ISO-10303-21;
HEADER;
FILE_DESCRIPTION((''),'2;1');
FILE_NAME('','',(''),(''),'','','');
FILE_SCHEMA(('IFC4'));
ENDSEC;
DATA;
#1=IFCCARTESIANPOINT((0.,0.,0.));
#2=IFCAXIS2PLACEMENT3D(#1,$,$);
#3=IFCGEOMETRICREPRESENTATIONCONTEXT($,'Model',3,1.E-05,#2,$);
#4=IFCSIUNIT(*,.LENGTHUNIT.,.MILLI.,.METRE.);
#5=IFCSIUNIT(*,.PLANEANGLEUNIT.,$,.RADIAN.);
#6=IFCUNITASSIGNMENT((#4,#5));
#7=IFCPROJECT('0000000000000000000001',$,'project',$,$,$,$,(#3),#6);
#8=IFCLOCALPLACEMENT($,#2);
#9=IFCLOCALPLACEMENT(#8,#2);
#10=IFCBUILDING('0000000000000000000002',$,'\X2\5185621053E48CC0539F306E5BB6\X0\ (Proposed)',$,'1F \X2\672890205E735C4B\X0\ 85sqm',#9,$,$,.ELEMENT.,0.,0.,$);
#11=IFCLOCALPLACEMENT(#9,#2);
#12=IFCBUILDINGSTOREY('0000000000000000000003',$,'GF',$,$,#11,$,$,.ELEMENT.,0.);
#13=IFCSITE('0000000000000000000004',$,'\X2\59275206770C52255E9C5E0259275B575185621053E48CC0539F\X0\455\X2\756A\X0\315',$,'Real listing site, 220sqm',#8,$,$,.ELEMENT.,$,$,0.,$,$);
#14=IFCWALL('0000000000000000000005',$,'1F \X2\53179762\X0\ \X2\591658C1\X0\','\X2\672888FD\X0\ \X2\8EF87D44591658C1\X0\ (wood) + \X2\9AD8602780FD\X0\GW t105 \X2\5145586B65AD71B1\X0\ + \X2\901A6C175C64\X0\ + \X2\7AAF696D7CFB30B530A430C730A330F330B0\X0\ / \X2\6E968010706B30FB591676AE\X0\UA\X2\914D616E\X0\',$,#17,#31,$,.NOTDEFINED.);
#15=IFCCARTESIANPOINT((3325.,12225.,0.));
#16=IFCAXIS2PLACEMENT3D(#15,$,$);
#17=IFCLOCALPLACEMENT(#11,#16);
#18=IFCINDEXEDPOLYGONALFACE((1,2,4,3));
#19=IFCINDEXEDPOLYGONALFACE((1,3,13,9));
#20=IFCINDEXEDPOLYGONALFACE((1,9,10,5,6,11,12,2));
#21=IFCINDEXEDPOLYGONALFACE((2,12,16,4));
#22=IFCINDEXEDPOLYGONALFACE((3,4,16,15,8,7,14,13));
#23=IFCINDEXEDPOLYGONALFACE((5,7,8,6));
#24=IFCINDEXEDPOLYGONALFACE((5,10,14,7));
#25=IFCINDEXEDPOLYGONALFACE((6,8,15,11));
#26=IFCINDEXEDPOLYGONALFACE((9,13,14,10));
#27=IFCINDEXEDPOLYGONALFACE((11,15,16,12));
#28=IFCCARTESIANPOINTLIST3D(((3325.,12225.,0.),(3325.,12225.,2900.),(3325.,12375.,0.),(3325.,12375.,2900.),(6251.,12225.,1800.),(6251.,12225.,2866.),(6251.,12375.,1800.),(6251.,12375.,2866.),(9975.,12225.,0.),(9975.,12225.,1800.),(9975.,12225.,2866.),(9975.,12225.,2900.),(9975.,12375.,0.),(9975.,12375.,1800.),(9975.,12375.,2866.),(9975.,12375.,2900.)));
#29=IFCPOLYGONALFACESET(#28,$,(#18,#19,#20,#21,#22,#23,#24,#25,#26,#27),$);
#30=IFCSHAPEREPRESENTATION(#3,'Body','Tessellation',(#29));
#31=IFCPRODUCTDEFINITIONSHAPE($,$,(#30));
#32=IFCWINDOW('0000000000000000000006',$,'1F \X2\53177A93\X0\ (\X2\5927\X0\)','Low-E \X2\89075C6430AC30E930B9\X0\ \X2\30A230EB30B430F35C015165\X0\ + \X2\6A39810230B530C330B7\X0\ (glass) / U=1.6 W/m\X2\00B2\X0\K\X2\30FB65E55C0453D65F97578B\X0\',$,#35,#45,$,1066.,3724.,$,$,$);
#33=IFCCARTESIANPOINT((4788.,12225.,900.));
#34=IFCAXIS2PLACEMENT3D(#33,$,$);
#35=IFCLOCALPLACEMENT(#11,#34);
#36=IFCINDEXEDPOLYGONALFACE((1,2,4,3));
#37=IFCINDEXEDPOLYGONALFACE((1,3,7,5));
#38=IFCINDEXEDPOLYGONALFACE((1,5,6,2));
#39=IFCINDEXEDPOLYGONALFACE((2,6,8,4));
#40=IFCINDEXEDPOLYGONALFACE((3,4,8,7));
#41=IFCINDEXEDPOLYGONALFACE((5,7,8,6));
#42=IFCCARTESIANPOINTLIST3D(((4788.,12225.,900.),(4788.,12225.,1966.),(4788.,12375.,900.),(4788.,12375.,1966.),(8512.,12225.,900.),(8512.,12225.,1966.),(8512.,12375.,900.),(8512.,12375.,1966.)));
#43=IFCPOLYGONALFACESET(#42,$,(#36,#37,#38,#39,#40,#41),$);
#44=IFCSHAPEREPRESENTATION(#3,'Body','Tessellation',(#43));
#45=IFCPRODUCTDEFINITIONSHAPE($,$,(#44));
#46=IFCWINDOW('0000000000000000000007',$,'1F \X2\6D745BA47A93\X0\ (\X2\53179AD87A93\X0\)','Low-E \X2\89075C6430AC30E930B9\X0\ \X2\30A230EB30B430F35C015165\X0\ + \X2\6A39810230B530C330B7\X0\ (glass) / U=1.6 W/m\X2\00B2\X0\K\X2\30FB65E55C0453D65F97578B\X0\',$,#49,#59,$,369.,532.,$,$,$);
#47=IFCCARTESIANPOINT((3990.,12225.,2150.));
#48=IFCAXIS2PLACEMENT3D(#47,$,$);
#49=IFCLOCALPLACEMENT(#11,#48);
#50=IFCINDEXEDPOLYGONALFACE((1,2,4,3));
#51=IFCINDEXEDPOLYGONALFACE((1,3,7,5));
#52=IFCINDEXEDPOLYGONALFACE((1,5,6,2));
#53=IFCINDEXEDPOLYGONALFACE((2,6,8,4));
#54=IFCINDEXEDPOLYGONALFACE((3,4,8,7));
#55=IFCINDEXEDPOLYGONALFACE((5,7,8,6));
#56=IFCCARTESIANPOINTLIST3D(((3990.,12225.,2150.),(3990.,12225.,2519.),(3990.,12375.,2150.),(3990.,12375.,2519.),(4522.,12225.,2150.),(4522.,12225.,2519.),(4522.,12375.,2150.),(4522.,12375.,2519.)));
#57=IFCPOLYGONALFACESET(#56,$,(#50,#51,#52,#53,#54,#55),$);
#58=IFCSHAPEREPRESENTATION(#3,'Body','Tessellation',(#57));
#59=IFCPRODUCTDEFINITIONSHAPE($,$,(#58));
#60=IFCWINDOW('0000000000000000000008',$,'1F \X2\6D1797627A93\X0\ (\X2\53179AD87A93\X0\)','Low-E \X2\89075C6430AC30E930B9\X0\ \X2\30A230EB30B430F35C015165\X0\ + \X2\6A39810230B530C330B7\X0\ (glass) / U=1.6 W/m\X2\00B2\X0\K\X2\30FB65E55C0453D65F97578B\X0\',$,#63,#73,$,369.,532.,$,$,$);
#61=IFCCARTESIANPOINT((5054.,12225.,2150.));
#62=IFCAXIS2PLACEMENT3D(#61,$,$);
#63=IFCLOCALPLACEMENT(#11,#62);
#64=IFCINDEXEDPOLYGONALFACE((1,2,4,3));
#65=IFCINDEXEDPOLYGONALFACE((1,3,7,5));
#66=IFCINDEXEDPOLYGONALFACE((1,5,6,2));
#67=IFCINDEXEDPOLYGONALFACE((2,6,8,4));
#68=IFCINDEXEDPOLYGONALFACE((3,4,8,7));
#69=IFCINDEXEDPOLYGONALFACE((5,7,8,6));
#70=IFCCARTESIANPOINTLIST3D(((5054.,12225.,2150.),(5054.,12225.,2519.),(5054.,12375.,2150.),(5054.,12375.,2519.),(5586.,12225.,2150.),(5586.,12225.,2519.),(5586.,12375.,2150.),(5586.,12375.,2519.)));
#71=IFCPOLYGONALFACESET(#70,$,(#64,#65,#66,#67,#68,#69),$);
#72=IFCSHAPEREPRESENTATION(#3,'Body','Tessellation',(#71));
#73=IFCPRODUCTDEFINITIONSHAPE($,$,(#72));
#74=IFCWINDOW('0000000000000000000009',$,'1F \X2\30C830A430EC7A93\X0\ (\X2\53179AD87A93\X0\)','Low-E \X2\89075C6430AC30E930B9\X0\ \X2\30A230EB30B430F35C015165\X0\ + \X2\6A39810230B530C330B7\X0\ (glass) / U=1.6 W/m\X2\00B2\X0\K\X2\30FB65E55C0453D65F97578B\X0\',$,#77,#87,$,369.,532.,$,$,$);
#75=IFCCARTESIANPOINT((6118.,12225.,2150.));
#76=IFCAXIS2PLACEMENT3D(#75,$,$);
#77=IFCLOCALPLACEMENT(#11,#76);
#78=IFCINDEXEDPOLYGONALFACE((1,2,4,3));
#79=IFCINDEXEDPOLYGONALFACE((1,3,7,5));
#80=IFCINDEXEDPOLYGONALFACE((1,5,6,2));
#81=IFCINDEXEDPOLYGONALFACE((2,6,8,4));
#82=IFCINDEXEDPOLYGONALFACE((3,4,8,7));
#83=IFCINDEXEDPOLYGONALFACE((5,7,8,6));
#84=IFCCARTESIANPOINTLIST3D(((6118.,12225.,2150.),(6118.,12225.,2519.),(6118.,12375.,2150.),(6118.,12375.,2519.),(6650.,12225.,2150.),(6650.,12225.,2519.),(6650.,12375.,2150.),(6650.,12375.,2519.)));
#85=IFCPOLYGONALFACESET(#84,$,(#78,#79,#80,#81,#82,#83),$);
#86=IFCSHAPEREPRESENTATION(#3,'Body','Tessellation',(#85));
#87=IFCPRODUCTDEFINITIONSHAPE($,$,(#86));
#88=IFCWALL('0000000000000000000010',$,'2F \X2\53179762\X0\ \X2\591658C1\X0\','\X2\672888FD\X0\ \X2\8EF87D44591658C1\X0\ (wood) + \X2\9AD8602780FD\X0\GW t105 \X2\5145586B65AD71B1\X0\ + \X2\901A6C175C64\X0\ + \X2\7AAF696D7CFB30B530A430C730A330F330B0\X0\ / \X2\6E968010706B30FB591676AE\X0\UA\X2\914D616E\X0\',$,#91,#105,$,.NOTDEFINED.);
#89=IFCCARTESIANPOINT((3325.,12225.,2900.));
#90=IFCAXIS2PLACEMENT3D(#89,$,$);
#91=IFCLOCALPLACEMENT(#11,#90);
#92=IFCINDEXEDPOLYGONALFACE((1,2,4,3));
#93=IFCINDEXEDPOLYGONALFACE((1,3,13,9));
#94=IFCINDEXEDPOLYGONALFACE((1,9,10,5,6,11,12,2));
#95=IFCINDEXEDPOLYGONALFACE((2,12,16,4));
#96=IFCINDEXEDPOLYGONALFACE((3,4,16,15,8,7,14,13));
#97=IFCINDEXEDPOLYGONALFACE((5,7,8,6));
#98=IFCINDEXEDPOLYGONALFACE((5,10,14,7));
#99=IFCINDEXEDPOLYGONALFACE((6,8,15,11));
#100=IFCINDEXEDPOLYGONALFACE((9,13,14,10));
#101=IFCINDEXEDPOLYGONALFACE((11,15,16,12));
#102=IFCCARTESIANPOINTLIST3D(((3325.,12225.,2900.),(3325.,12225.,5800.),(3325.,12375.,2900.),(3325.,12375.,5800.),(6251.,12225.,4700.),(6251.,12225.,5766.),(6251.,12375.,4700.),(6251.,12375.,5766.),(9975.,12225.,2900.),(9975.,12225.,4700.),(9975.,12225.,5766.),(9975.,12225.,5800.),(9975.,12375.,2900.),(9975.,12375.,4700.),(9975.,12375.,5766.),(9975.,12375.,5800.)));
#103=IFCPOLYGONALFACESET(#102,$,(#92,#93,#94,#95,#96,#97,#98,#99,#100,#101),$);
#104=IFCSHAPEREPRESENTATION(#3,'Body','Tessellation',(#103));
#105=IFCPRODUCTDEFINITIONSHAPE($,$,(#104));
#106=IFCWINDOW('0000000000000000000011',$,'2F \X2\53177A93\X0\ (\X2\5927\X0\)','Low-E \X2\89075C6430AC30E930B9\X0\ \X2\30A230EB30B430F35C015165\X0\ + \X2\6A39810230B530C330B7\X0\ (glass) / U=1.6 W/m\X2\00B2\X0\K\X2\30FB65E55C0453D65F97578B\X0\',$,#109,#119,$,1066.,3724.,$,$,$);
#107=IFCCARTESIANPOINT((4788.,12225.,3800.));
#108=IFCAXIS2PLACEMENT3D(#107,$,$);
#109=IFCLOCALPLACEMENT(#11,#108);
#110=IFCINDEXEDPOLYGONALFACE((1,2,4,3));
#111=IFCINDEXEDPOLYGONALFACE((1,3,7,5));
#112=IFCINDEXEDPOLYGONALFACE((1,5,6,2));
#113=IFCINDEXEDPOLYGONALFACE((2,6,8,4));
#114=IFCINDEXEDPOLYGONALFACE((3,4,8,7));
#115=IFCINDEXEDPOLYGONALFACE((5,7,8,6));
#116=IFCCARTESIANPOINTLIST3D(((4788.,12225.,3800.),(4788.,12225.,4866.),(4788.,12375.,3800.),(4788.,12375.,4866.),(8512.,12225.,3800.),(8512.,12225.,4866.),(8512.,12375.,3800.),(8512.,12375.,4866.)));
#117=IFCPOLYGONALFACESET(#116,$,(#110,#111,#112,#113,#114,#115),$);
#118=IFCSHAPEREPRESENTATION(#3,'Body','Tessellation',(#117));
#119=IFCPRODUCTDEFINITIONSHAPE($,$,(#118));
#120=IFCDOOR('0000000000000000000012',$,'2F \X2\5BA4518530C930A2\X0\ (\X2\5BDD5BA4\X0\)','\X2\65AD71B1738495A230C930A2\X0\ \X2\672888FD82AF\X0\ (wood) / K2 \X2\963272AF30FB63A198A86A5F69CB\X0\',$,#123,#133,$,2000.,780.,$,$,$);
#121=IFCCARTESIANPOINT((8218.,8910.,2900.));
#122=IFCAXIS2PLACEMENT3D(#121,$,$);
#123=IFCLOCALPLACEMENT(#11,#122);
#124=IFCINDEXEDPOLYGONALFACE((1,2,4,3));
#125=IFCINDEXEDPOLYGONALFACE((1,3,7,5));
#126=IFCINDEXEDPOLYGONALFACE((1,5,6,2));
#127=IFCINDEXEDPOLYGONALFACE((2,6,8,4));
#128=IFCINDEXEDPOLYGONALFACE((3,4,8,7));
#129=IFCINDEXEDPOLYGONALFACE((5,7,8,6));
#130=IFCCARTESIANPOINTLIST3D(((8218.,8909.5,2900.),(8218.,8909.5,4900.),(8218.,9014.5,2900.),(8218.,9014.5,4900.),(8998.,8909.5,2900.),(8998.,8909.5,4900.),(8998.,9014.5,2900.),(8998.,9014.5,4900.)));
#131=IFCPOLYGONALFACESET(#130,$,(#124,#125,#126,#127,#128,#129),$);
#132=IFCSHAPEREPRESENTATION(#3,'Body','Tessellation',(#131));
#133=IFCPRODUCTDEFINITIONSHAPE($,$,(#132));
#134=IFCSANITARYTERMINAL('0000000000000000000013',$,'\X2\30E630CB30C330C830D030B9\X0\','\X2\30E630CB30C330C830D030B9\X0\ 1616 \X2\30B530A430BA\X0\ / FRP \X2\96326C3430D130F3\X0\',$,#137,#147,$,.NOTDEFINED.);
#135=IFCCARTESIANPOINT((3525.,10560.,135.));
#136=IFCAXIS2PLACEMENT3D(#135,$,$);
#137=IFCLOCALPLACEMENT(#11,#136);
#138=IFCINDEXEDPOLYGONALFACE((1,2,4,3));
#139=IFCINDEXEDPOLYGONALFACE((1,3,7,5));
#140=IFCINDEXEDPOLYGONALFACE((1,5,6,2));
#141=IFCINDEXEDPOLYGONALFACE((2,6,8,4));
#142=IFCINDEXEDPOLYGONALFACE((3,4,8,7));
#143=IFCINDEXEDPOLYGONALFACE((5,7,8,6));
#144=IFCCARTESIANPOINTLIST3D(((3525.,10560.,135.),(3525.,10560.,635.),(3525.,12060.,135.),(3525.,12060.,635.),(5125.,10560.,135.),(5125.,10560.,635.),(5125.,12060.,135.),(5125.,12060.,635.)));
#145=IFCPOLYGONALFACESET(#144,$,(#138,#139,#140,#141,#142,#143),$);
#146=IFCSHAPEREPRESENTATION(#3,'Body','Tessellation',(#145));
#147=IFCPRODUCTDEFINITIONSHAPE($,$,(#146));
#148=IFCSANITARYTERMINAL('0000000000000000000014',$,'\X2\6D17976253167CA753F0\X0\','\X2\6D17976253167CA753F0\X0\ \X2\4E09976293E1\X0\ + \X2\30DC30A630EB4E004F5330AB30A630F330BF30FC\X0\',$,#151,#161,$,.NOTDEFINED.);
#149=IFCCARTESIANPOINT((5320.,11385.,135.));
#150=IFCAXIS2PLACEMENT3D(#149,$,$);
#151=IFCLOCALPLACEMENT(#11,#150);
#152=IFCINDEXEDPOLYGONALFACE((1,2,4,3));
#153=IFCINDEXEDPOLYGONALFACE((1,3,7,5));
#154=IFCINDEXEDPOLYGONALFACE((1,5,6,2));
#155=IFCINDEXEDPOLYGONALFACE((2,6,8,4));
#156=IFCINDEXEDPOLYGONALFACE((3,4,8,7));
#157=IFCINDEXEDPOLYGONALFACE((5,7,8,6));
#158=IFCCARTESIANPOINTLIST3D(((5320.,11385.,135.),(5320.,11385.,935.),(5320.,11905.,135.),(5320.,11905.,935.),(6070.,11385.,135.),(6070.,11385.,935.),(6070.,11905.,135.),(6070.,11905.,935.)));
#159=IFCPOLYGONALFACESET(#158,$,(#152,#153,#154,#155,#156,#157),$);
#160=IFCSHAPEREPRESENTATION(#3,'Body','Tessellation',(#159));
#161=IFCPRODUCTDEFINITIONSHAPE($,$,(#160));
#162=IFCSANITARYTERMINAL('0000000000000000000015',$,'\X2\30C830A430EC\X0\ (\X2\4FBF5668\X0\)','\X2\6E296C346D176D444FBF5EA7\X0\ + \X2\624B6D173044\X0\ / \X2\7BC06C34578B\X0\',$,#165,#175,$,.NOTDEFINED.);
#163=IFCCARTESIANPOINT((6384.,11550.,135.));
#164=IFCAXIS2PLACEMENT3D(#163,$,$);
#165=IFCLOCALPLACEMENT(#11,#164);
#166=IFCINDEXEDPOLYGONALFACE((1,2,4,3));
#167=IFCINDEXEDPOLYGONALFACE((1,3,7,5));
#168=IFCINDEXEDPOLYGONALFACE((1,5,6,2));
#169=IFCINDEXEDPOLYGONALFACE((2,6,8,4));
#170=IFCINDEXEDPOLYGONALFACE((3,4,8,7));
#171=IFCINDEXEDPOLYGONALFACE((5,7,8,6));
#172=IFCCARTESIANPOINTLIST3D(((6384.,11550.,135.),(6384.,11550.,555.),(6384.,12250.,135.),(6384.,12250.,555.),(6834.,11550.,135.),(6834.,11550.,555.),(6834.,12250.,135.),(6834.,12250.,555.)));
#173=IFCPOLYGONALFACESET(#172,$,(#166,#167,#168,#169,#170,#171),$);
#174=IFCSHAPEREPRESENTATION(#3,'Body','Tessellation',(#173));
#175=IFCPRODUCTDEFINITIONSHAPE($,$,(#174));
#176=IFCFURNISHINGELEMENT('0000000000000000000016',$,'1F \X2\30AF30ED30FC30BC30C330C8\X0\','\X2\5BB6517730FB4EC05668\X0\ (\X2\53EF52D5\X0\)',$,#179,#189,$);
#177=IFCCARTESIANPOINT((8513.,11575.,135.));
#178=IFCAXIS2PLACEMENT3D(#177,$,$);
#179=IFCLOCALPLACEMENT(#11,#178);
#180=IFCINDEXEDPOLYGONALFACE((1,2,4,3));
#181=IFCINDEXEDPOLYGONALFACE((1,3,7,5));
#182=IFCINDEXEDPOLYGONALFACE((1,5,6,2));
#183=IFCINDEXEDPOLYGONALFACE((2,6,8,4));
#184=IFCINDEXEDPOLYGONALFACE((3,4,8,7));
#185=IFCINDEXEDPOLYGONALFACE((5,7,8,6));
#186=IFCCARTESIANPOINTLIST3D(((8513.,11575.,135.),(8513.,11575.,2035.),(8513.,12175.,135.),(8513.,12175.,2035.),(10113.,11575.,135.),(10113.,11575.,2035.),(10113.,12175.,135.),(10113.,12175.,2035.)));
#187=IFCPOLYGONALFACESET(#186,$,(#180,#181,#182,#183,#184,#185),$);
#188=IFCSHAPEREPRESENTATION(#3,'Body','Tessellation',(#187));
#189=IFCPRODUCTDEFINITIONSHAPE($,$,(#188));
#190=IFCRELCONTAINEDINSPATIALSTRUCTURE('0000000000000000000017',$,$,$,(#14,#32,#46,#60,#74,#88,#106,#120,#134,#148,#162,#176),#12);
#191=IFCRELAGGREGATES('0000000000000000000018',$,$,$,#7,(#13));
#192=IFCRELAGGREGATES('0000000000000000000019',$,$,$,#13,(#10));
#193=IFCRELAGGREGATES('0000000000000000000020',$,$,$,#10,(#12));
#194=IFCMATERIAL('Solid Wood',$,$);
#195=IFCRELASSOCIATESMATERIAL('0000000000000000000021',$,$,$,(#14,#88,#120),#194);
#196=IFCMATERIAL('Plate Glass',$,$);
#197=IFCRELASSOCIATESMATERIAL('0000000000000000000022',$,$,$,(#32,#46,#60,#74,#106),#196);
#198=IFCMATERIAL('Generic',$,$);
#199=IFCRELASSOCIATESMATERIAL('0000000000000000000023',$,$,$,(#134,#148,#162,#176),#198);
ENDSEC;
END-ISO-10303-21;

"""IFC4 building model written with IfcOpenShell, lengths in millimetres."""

from ifc_helpers import new_model, si_unit, frame, frame_2d, origin, place, context, project, spatial, rectangle, extrude, material, element, fill, save


model = new_model("IFC4")

# Units and contexts
model_context = context("Model", 3, precision=1e-05, world=origin())
ifc_project = project(units=[si_unit("LENGTHUNIT", "METRE", prefix="MILLI"), si_unit("PLANEANGLEUNIT", "RADIAN")], contexts=[model_context])

# Site, building, storey
site_placement = place(None, origin())
site = spatial("IfcSite", under=ifc_project, at=site_placement, Name="大分県別府市大字内成古賀原455番315", ObjectType="Real listing site, 220sqm", CompositionType="ELEMENT", RefElevation=0.0)
building_placement = place(site_placement, origin())
building = spatial("IfcBuilding", under=site, at=building_placement, Name="内成古賀原の家 (Proposed)", ObjectType="1F 木造平屋 85sqm", CompositionType="ELEMENT", ElevationOfRefHeight=0.0, ElevationOfTerrain=0.0)
storey_placement = place(building_placement, origin())
storey = spatial("IfcBuildingStorey", under=building, at=storey_placement, Name="GF", CompositionType="ELEMENT", Elevation=0.0)

# Wall, openings, windows
ifc_material_1 = material(Name="Solid Wood")
wall_1_placement = place(storey_placement, frame((3325.0, 12225.0, 0.0)))
wall_1 = element("IfcWall", 1, at=wall_1_placement, inside=storey, material=ifc_material_1, Name="1F 北面 外壁", Description="木製 軸組外壁 (wood) + 高性能GW t105 充填断熱 + 通気層 + 窯業系サイディング / 準耐火・外皮UA配慮", PredefinedType="NOTDEFINED", context=model_context, shape_type="SweptSolid", body=[
    extrude(rectangle(XDim=6650.0, YDim=150.0, at=frame_2d((3325.0, 75.0))), frame((3325.0, 12225.0, 0.0)), (0.0, 0.0, 1.0), 2900.0),
])
opening_1_placement = place(storey_placement, frame((4788.0, 12225.0, 900.0)))
opening_1 = element("IfcOpeningElement", 2, at=opening_1_placement, cuts=wall_1, PredefinedType="NOTDEFINED", context=model_context, shape_type="SweptSolid", body=[
    extrude(rectangle(XDim=3724.0, YDim=150.0, at=frame_2d((1862.0, 75.0))), frame((4788.0, 12225.0, 900.0)), (0.0, 0.0, 1.0), 1066.0),
])
opening_2_placement = place(storey_placement, frame((3990.0, 12225.0, 2150.0)))
opening_2 = element("IfcOpeningElement", 3, at=opening_2_placement, cuts=wall_1, PredefinedType="NOTDEFINED", context=model_context, shape_type="SweptSolid", body=[
    extrude(rectangle(XDim=532.0, YDim=150.0, at=frame_2d((266.0, 75.0))), frame((3990.0, 12225.0, 2150.0)), (0.0, 0.0, 1.0), 369.0),
])
opening_3_placement = place(storey_placement, frame((5054.0, 12225.0, 2150.0)))
opening_3 = element("IfcOpeningElement", 4, at=opening_3_placement, cuts=wall_1, PredefinedType="NOTDEFINED", context=model_context, shape_type="SweptSolid", body=[
    extrude(rectangle(XDim=532.0, YDim=150.0, at=frame_2d((266.0, 75.0))), frame((5054.0, 12225.0, 2150.0)), (0.0, 0.0, 1.0), 369.0),
])
opening_4_placement = place(storey_placement, frame((6118.0, 12225.0, 2150.0)))
opening_4 = element("IfcOpeningElement", 5, at=opening_4_placement, cuts=wall_1, PredefinedType="NOTDEFINED", context=model_context, shape_type="SweptSolid", body=[
    extrude(rectangle(XDim=532.0, YDim=150.0, at=frame_2d((266.0, 75.0))), frame((6118.0, 12225.0, 2150.0)), (0.0, 0.0, 1.0), 369.0),
])
ifc_material_2 = material(Name="Plate Glass")
window_1_placement = place(storey_placement, frame((4788.0, 12225.0, 900.0)))
window_1 = element("IfcWindow", 6, at=window_1_placement, inside=storey, material=ifc_material_2, Name="1F 北窓 (大)", Description="Low-E 複層ガラス アルゴン封入 + 樹脂サッシ (glass) / U=1.6 W/m²K・日射取得型", OverallHeight=1066.0, OverallWidth=3724.0, context=model_context, shape_type="SweptSolid", body=[
    extrude(rectangle(XDim=3724.0, YDim=150.0, at=frame_2d((1862.0, 75.0))), frame((4788.0, 12225.0, 900.0)), (0.0, 0.0, 1.0), 1066.0),
])
fill(opening_1, window_1)
window_2_placement = place(storey_placement, frame((3990.0, 12225.0, 2150.0)))
window_2 = element("IfcWindow", 7, at=window_2_placement, inside=storey, material=ifc_material_2, Name="1F 浴室窓 (北高窓)", Description="Low-E 複層ガラス アルゴン封入 + 樹脂サッシ (glass) / U=1.6 W/m²K・日射取得型", OverallHeight=369.0, OverallWidth=532.0, context=model_context, shape_type="SweptSolid", body=[
    extrude(rectangle(XDim=532.0, YDim=150.0, at=frame_2d((266.0, 75.0))), frame((3990.0, 12225.0, 2150.0)), (0.0, 0.0, 1.0), 369.0),
])
fill(opening_2, window_2)
window_3_placement = place(storey_placement, frame((5054.0, 12225.0, 2150.0)))
window_3 = element("IfcWindow", 8, at=window_3_placement, inside=storey, material=ifc_material_2, Name="1F 洗面窓 (北高窓)", Description="Low-E 複層ガラス アルゴン封入 + 樹脂サッシ (glass) / U=1.6 W/m²K・日射取得型", OverallHeight=369.0, OverallWidth=532.0, context=model_context, shape_type="SweptSolid", body=[
    extrude(rectangle(XDim=532.0, YDim=150.0, at=frame_2d((266.0, 75.0))), frame((5054.0, 12225.0, 2150.0)), (0.0, 0.0, 1.0), 369.0),
])
fill(opening_3, window_3)
window_4_placement = place(storey_placement, frame((6118.0, 12225.0, 2150.0)))
window_4 = element("IfcWindow", 9, at=window_4_placement, inside=storey, material=ifc_material_2, Name="1F トイレ窓 (北高窓)", Description="Low-E 複層ガラス アルゴン封入 + 樹脂サッシ (glass) / U=1.6 W/m²K・日射取得型", OverallHeight=369.0, OverallWidth=532.0, context=model_context, shape_type="SweptSolid", body=[
    extrude(rectangle(XDim=532.0, YDim=150.0, at=frame_2d((266.0, 75.0))), frame((6118.0, 12225.0, 2150.0)), (0.0, 0.0, 1.0), 369.0),
])
fill(opening_4, window_4)

# Wall, opening, window
wall_2_placement = place(storey_placement, frame((3325.0, 12225.0, 2900.0)))
wall_2 = element("IfcWall", 10, at=wall_2_placement, inside=storey, material=ifc_material_1, Name="2F 北面 外壁", Description="木製 軸組外壁 (wood) + 高性能GW t105 充填断熱 + 通気層 + 窯業系サイディング / 準耐火・外皮UA配慮", PredefinedType="NOTDEFINED", context=model_context, shape_type="SweptSolid", body=[
    extrude(rectangle(XDim=6650.0, YDim=150.0, at=frame_2d((3325.0, 75.0))), frame((3325.0, 12225.0, 2900.0)), (0.0, 0.0, 1.0), 2900.0),
])
opening_5_placement = place(storey_placement, frame((4788.0, 12225.0, 3800.0)))
opening_5 = element("IfcOpeningElement", 11, at=opening_5_placement, cuts=wall_2, PredefinedType="NOTDEFINED", context=model_context, shape_type="SweptSolid", body=[
    extrude(rectangle(XDim=3724.0, YDim=150.0, at=frame_2d((1862.0, 75.0))), frame((4788.0, 12225.0, 3800.0)), (0.0, 0.0, 1.0), 1066.0),
])
window_5_placement = place(storey_placement, frame((4788.0, 12225.0, 3800.0)))
window_5 = element("IfcWindow", 12, at=window_5_placement, inside=storey, material=ifc_material_2, Name="2F 北窓 (大)", Description="Low-E 複層ガラス アルゴン封入 + 樹脂サッシ (glass) / U=1.6 W/m²K・日射取得型", OverallHeight=1066.0, OverallWidth=3724.0, context=model_context, shape_type="SweptSolid", body=[
    extrude(rectangle(XDim=3724.0, YDim=150.0, at=frame_2d((1862.0, 75.0))), frame((4788.0, 12225.0, 3800.0)), (0.0, 0.0, 1.0), 1066.0),
])
fill(opening_5, window_5)

# Door
door_1_placement = place(storey_placement, frame((8218.0, 8910.0, 2900.0)))
element("IfcDoor", 13, at=door_1_placement, inside=storey, material=ifc_material_1, Name="2F 室内ドア (寝室)", Description="断熱玄関ドア 木製芯 (wood) / K2 防犯・採風機構", OverallHeight=2000.0, OverallWidth=780.0, context=model_context, shape_type="SweptSolid", body=[
    extrude(rectangle(XDim=780.0, YDim=105.0, at=frame_2d((390.0, 52.0))), frame((8218.0, 8910.0, 2900.0)), (0.0, 0.0, 1.0), 2000.0),
])

# Sanitary terminals
ifc_material_3 = material(Name="Generic")
sanitary_terminal_1_placement = place(storey_placement, frame((3525.0, 10560.0, 135.0)))
element("IfcSanitaryTerminal", 14, at=sanitary_terminal_1_placement, inside=storey, material=ifc_material_3, Name="ユニットバス", Description="ユニットバス 1616 サイズ / FRP 防水パン", PredefinedType="NOTDEFINED", context=model_context, shape_type="SweptSolid", body=[
    extrude(rectangle(XDim=1600.0, YDim=1500.0, at=frame_2d((800.0, 750.0))), frame((3525.0, 10560.0, 135.0)), (0.0, 0.0, 1.0), 500.0),
])
sanitary_terminal_2_placement = place(storey_placement, frame((5320.0, 11385.0, 135.0)))
element("IfcSanitaryTerminal", 15, at=sanitary_terminal_2_placement, inside=storey, material=ifc_material_3, Name="洗面化粧台", Description="洗面化粧台 三面鏡 + ボウル一体カウンター", PredefinedType="NOTDEFINED", context=model_context, shape_type="SweptSolid", body=[
    extrude(rectangle(XDim=750.0, YDim=520.0, at=frame_2d((375.0, 260.0))), frame((5320.0, 11385.0, 135.0)), (0.0, 0.0, 1.0), 800.0),
])
sanitary_terminal_3_placement = place(storey_placement, frame((6384.0, 11550.0, 135.0)))
element("IfcSanitaryTerminal", 16, at=sanitary_terminal_3_placement, inside=storey, material=ifc_material_3, Name="トイレ (便器)", Description="温水洗浄便座 + 手洗い / 節水型", PredefinedType="NOTDEFINED", context=model_context, shape_type="SweptSolid", body=[
    extrude(rectangle(XDim=450.0, YDim=700.0, at=frame_2d((225.0, 350.0))), frame((6384.0, 11550.0, 135.0)), (0.0, 0.0, 1.0), 420.0),
])

# Furnishing element
furnishing_1_placement = place(storey_placement, frame((8513.0, 11575.0, 135.0)))
element("IfcFurnishingElement", 17, at=furnishing_1_placement, inside=storey, material=ifc_material_3, Name="1F クローゼット", Description="家具・什器 (可動)", context=model_context, shape_type="SweptSolid", body=[
    extrude(rectangle(XDim=1600.0, YDim=600.0, at=frame_2d((800.0, 300.0))), frame((8513.0, 11575.0, 135.0)), (0.0, 0.0, 1.0), 1900.0),
])

save(model, "model.ifc")
